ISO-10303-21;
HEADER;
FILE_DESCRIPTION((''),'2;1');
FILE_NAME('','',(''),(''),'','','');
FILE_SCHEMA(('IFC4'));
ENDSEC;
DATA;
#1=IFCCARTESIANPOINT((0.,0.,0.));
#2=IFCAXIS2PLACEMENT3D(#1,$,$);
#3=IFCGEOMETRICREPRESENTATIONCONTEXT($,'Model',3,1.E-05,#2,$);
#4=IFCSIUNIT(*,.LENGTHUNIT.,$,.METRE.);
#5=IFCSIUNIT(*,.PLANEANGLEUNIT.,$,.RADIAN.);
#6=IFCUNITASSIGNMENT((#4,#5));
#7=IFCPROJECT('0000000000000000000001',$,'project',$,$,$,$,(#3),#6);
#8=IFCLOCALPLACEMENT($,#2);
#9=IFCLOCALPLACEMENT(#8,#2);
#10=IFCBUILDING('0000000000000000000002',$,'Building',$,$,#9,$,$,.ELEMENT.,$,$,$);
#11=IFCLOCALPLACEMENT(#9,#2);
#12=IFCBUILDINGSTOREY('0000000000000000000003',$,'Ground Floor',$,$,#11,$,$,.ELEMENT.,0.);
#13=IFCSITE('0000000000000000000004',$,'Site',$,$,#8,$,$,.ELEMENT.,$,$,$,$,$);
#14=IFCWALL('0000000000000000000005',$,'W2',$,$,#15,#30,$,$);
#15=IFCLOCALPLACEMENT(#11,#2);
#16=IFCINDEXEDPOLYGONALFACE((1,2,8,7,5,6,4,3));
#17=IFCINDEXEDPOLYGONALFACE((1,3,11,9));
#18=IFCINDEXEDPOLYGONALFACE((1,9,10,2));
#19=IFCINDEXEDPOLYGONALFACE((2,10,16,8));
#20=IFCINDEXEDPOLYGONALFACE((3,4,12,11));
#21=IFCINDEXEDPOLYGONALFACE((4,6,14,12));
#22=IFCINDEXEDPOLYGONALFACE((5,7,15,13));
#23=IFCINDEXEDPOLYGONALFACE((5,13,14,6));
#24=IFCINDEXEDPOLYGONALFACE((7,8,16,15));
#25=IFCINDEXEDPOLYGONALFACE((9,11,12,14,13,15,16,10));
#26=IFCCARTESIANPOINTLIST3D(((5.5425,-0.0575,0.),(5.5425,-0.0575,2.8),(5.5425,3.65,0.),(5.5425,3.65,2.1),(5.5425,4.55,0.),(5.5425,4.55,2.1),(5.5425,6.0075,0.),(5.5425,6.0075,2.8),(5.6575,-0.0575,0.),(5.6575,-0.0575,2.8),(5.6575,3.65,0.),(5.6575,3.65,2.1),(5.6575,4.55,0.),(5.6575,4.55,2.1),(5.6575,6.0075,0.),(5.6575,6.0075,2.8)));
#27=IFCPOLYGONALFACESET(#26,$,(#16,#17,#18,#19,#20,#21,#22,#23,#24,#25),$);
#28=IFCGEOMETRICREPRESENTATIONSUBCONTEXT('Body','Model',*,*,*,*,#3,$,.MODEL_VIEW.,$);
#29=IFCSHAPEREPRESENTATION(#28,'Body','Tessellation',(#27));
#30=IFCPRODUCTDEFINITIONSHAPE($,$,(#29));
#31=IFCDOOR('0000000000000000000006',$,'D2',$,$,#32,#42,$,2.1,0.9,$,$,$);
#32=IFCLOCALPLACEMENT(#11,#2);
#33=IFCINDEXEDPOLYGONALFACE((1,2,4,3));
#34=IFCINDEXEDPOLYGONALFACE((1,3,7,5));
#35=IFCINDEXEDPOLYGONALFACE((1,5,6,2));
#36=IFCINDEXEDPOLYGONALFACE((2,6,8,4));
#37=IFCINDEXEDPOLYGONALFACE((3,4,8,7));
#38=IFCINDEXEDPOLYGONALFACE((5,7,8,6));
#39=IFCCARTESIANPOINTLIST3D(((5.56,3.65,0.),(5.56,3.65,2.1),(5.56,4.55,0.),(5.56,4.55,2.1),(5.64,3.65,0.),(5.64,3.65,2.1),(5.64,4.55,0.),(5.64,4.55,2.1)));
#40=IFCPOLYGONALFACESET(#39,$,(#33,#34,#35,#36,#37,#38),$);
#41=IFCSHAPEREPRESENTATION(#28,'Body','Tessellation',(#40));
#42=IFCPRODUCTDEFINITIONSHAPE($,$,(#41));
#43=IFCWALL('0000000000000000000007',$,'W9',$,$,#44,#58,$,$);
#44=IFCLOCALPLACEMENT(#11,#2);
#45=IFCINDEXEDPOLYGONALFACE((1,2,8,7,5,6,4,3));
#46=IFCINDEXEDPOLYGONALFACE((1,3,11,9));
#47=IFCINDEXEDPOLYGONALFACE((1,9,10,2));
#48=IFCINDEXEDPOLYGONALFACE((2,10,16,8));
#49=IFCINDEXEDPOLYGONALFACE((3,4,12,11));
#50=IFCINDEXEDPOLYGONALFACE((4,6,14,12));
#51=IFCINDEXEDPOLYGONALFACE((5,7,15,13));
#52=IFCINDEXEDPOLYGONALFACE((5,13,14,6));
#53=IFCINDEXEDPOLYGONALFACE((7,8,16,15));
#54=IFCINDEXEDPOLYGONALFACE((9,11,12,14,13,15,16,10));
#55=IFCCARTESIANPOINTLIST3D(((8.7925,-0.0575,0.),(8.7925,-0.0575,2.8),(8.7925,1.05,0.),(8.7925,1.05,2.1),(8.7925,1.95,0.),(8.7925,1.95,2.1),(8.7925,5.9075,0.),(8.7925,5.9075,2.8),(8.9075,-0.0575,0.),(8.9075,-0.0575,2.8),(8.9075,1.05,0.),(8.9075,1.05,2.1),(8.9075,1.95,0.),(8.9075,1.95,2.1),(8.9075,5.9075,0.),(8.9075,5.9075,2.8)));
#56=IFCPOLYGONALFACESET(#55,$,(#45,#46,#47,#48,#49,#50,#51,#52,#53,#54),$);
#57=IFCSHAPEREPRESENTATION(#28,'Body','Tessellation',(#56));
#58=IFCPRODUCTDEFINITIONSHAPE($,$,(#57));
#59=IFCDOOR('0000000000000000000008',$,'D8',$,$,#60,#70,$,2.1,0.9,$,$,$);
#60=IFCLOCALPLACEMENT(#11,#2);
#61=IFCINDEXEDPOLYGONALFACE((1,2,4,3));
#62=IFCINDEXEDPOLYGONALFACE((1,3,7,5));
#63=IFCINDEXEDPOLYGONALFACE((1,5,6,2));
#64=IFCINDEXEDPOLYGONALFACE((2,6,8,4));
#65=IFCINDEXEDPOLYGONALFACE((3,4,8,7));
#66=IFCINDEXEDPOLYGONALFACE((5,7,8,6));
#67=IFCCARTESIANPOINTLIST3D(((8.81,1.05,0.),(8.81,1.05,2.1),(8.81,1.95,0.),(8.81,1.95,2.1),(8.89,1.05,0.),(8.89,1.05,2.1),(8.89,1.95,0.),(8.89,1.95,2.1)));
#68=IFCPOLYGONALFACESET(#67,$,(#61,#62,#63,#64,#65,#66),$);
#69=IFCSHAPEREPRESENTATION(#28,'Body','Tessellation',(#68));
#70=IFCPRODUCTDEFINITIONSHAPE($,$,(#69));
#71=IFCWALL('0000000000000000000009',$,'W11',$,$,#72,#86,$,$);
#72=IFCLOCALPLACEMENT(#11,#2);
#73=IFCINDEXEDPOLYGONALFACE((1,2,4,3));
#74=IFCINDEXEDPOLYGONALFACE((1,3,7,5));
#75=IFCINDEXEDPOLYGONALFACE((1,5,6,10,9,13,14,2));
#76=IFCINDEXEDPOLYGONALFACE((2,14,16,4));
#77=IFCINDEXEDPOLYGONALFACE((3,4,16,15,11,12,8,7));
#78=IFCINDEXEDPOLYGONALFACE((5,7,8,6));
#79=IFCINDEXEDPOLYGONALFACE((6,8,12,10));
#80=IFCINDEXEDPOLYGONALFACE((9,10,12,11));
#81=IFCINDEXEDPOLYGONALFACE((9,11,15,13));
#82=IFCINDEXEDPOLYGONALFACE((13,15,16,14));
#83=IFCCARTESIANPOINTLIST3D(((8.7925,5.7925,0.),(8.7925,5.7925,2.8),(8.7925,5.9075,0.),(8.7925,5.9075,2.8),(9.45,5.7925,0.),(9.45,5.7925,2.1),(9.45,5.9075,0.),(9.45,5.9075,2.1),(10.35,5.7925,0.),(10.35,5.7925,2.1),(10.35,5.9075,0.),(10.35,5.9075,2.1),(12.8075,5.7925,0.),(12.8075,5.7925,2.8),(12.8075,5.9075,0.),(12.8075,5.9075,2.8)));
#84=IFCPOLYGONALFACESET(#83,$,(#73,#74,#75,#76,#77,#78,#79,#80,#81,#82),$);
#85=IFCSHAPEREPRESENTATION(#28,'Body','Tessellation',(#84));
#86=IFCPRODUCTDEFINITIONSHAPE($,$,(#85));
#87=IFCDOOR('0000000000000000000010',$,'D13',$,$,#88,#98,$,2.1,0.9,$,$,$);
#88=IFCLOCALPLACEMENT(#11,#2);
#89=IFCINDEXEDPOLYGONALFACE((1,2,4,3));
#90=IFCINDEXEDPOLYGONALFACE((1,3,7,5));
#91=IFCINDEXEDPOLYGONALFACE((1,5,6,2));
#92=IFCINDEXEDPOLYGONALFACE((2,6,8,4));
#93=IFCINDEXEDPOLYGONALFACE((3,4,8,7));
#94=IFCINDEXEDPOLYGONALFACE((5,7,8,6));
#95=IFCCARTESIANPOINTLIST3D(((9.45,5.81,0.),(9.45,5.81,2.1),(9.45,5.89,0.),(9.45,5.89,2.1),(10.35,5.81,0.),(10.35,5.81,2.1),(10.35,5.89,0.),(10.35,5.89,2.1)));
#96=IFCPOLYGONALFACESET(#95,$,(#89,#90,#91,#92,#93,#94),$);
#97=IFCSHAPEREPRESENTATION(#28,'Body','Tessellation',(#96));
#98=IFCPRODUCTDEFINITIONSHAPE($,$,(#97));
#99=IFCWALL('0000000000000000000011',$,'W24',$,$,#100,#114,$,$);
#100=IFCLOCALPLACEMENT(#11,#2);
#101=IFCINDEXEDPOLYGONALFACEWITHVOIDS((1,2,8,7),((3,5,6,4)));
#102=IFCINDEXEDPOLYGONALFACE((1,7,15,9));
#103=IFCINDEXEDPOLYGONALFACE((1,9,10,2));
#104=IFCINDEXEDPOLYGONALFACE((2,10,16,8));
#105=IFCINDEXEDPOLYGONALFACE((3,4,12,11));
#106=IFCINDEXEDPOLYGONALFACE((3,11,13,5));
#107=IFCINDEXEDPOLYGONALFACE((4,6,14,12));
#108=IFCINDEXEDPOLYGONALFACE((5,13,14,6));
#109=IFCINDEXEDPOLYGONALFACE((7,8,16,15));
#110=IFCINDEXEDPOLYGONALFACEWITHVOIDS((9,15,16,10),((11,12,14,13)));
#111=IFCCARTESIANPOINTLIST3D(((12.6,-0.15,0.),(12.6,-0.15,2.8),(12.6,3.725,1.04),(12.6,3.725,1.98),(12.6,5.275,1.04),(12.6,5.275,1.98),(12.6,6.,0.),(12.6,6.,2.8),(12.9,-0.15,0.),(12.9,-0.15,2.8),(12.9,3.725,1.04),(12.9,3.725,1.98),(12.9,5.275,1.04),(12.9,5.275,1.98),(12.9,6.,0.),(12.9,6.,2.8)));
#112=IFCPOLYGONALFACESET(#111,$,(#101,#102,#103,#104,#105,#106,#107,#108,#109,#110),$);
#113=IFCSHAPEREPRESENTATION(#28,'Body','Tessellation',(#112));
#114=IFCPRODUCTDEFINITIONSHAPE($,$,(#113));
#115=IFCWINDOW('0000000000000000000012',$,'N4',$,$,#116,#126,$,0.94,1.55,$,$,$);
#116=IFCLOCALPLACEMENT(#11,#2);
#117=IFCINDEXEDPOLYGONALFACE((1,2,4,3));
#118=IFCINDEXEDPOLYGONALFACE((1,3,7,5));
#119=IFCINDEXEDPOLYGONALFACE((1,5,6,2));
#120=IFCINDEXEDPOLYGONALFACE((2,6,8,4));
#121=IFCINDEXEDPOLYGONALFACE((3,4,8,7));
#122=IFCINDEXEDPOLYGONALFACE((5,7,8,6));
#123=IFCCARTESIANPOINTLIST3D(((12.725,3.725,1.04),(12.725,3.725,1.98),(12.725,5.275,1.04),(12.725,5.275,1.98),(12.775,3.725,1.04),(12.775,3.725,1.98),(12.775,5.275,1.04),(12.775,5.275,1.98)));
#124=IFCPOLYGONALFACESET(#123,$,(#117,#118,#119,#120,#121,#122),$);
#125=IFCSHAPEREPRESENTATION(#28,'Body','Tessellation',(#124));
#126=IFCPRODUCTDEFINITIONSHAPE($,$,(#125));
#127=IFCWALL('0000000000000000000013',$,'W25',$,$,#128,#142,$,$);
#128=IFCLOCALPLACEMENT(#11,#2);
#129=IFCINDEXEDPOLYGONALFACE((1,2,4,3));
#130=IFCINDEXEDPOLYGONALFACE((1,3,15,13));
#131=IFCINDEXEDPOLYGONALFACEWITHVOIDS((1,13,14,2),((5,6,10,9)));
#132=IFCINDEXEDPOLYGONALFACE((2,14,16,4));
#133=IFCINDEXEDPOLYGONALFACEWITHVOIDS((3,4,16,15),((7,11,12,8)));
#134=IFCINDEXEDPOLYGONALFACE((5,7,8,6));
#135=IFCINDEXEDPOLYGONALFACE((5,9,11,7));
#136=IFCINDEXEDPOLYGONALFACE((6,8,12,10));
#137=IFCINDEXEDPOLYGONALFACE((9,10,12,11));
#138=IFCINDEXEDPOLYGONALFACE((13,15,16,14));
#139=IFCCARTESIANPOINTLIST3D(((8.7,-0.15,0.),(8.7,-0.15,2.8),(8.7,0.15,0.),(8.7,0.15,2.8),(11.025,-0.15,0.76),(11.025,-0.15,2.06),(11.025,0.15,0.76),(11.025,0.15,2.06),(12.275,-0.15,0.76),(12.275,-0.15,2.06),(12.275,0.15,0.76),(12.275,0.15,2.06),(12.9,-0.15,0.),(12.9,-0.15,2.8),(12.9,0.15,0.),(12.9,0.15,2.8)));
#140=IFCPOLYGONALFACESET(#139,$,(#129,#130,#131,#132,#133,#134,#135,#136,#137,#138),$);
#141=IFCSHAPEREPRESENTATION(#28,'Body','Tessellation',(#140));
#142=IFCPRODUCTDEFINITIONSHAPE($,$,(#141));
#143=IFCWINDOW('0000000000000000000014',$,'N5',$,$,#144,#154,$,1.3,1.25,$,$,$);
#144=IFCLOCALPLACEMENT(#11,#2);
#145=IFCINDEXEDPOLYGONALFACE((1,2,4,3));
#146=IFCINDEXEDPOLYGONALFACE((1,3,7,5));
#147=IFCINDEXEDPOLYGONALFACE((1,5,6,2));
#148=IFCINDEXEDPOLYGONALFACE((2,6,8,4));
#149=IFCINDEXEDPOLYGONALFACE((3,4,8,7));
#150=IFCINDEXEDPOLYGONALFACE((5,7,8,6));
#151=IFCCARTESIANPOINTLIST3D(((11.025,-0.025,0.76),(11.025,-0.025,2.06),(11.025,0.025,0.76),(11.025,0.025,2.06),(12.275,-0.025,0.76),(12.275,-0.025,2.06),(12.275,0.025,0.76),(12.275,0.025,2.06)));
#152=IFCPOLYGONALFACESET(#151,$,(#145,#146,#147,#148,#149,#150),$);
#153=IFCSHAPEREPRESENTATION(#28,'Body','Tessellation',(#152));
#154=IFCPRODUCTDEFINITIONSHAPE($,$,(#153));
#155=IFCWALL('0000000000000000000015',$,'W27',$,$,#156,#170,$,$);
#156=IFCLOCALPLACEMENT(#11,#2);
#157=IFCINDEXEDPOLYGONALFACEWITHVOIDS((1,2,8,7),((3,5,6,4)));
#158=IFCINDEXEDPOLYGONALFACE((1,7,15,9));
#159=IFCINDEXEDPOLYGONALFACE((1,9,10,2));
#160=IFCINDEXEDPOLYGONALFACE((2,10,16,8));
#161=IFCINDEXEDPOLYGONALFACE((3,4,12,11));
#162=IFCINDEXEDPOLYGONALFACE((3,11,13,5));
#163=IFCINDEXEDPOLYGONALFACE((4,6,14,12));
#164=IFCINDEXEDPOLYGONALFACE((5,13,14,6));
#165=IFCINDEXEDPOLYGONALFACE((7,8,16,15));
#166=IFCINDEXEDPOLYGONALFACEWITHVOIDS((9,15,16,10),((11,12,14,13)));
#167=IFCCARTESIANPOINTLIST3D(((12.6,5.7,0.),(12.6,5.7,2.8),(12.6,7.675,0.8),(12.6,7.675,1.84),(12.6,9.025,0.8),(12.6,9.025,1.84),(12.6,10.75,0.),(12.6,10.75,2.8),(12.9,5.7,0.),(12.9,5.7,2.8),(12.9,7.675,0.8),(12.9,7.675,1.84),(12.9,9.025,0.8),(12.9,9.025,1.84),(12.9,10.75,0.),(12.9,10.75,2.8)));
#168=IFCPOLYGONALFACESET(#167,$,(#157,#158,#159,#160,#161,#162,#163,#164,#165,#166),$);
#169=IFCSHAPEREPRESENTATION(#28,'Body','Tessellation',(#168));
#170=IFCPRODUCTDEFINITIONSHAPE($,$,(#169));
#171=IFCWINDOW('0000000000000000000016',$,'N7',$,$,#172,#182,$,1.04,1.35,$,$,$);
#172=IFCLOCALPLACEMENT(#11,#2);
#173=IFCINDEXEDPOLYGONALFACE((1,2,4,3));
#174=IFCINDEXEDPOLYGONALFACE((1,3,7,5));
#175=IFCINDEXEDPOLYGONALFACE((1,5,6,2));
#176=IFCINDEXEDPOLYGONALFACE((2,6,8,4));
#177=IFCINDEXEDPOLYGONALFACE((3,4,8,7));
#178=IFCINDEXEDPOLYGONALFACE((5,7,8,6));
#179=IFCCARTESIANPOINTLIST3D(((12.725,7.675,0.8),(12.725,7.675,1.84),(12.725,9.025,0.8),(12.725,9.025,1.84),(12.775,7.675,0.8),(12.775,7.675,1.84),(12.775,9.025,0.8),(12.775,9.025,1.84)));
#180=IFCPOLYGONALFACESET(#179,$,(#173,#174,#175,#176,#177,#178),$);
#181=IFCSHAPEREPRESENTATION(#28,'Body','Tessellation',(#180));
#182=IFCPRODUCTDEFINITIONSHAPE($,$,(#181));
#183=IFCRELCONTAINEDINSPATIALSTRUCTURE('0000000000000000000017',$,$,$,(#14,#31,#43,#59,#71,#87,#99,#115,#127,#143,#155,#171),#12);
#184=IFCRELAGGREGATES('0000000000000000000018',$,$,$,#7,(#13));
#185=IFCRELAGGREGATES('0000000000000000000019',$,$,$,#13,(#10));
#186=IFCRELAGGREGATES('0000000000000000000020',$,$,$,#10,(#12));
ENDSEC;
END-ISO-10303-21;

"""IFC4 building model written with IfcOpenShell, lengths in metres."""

from ifc_helpers import new_model, si_unit, frame, frame_2d, origin, origin_2d, place, context, subcontext, project, spatial, rectangle, extrude, element, fill, save


model = new_model("IFC4")

# Units and contexts
model_context = context("Model", 3, precision=1e-05, world=origin())
body_context = subcontext(model_context, "Body", "Model", "MODEL_VIEW")
ifc_project = project(units=[si_unit("LENGTHUNIT", "METRE"), si_unit("PLANEANGLEUNIT", "RADIAN")], contexts=[model_context])

# Site, building, storey
site_placement = place(None, origin())
site = spatial("IfcSite", under=ifc_project, at=site_placement, Name="Site", CompositionType="ELEMENT")
building_placement = place(site_placement, origin())
building = spatial("IfcBuilding", under=site, at=building_placement, Name="Building", CompositionType="ELEMENT")
storey_placement = place(building_placement, origin())
storey = spatial("IfcBuildingStorey", under=building, at=storey_placement, Name="Ground Floor", CompositionType="ELEMENT", Elevation=0.0)

# Walls, openings, doors
wall_1_placement = place(storey_placement, frame((5.6, 0.0, 0.0), x_axis=(0.0, 1.0, 0.0)))
wall_1 = element("IfcWall", 1, at=wall_1_placement, inside=storey, Name="W2", context=body_context, shape_type="SweptSolid", body=[
    extrude(rectangle(XDim=6.065, YDim=0.115, at=frame_2d((2.975, 0.0))), origin(), (0.0, 0.0, 1.0), 2.8),
])
opening_1_placement = place(wall_1_placement, frame((4.1, 0.0, 0.0)))
opening_1 = element("IfcOpeningElement", 2, at=opening_1_placement, cuts=wall_1, context=body_context, shape_type="SweptSolid", body=[
    extrude(rectangle(XDim=0.9, YDim=0.215, at=origin_2d()), origin(), (0.0, 0.0, 1.0), 2.1),
])
door_1_placement = place(opening_1_placement, origin())
door_1 = element("IfcDoor", 3, at=door_1_placement, inside=storey, Name="D2", OverallHeight=2.1, OverallWidth=0.9, context=body_context, shape_type="SweptSolid", body=[
    extrude(rectangle(XDim=0.9, YDim=0.08, at=origin_2d()), origin(), (0.0, 0.0, 1.0), 2.1),
])
fill(opening_1, door_1)
wall_2_placement = place(storey_placement, frame((8.85, 0.0, 0.0), x_axis=(0.0, 1.0, 0.0)))
wall_2 = element("IfcWall", 4, at=wall_2_placement, inside=storey, Name="W9", context=body_context, shape_type="SweptSolid", body=[
    extrude(rectangle(XDim=5.965, YDim=0.115, at=frame_2d((2.925, 0.0))), origin(), (0.0, 0.0, 1.0), 2.8),
])
opening_2_placement = place(wall_2_placement, frame((1.5, 0.0, 0.0)))
opening_2 = element("IfcOpeningElement", 5, at=opening_2_placement, cuts=wall_2, context=body_context, shape_type="SweptSolid", body=[
    extrude(rectangle(XDim=0.9, YDim=0.215, at=origin_2d()), origin(), (0.0, 0.0, 1.0), 2.1),
])
door_2_placement = place(opening_2_placement, origin())
door_2 = element("IfcDoor", 6, at=door_2_placement, inside=storey, Name="D8", OverallHeight=2.1, OverallWidth=0.9, context=body_context, shape_type="SweptSolid", body=[
    extrude(rectangle(XDim=0.9, YDim=0.08, at=origin_2d()), origin(), (0.0, 0.0, 1.0), 2.1),
])
fill(opening_2, door_2)
wall_3_placement = place(storey_placement, frame((8.85, 5.85, 0.0), x_axis=(1.0, 0.0, 0.0)))
wall_3 = element("IfcWall", 7, at=wall_3_placement, inside=storey, Name="W11", context=body_context, shape_type="SweptSolid", body=[
    extrude(rectangle(XDim=4.015, YDim=0.115, at=frame_2d((1.95, 0.0))), origin(), (0.0, 0.0, 1.0), 2.8),
])
opening_3_placement = place(wall_3_placement, frame((1.05, 0.0, 0.0)))
opening_3 = element("IfcOpeningElement", 8, at=opening_3_placement, cuts=wall_3, context=body_context, shape_type="SweptSolid", body=[
    extrude(rectangle(XDim=0.9, YDim=0.215, at=origin_2d()), origin(), (0.0, 0.0, 1.0), 2.1),
])
door_3_placement = place(opening_3_placement, origin())
door_3 = element("IfcDoor", 9, at=door_3_placement, inside=storey, Name="D13", OverallHeight=2.1, OverallWidth=0.9, context=body_context, shape_type="SweptSolid", body=[
    extrude(rectangle(XDim=0.9, YDim=0.08, at=origin_2d()), origin(), (0.0, 0.0, 1.0), 2.1),
])
fill(opening_3, door_3)

# Walls, openings, windows
wall_4_placement = place(storey_placement, frame((12.75, 0.0, 0.0), x_axis=(0.0, 1.0, 0.0)))
wall_4 = element("IfcWall", 10, at=wall_4_placement, inside=storey, Name="W24", context=body_context, shape_type="SweptSolid", body=[
    extrude(rectangle(XDim=6.15, YDim=0.3, at=frame_2d((2.925, 0.0))), origin(), (0.0, 0.0, 1.0), 2.8),
])
opening_4_placement = place(wall_4_placement, frame((4.5, 0.0, 1.04)))
opening_4 = element("IfcOpeningElement", 11, at=opening_4_placement, cuts=wall_4, context=body_context, shape_type="SweptSolid", body=[
    extrude(rectangle(XDim=1.55, YDim=0.4, at=origin_2d()), origin(), (0.0, 0.0, 1.0), 0.94),
])
window_1_placement = place(opening_4_placement, origin())
window_1 = element("IfcWindow", 12, at=window_1_placement, inside=storey, Name="N4", OverallHeight=0.94, OverallWidth=1.55, context=body_context, shape_type="SweptSolid", body=[
    extrude(rectangle(XDim=1.55, YDim=0.05, at=origin_2d()), origin(), (0.0, 0.0, 1.0), 0.94),
])
fill(opening_4, window_1)
wall_5_placement = place(storey_placement, frame((8.85, 0.0, 0.0), x_axis=(1.0, 0.0, 0.0)))
wall_5 = element("IfcWall", 13, at=wall_5_placement, inside=storey, Name="W25", context=body_context, shape_type="SweptSolid", body=[
    extrude(rectangle(XDim=4.2, YDim=0.3, at=frame_2d((1.95, 0.0))), origin(), (0.0, 0.0, 1.0), 2.8),
])
opening_5_placement = place(wall_5_placement, frame((2.8, 0.0, 0.76)))
opening_5 = element("IfcOpeningElement", 14, at=opening_5_placement, cuts=wall_5, context=body_context, shape_type="SweptSolid", body=[
    extrude(rectangle(XDim=1.25, YDim=0.4, at=origin_2d()), origin(), (0.0, 0.0, 1.0), 1.3),
])
window_2_placement = place(opening_5_placement, origin())
window_2 = element("IfcWindow", 15, at=window_2_placement, inside=storey, Name="N5", OverallHeight=1.3, OverallWidth=1.25, context=body_context, shape_type="SweptSolid", body=[
    extrude(rectangle(XDim=1.25, YDim=0.05, at=origin_2d()), origin(), (0.0, 0.0, 1.0), 1.3),
])
fill(opening_5, window_2)
wall_6_placement = place(storey_placement, frame((12.75, 5.85, 0.0), x_axis=(0.0, 1.0, 0.0)))
wall_6 = element("IfcWall", 16, at=wall_6_placement, inside=storey, Name="W27", context=body_context, shape_type="SweptSolid", body=[
    extrude(rectangle(XDim=5.05, YDim=0.3, at=frame_2d((2.375, 0.0))), origin(), (0.0, 0.0, 1.0), 2.8),
])
opening_6_placement = place(wall_6_placement, frame((2.5, 0.0, 0.8)))
opening_6 = element("IfcOpeningElement", 17, at=opening_6_placement, cuts=wall_6, context=body_context, shape_type="SweptSolid", body=[
    extrude(rectangle(XDim=1.35, YDim=0.4, at=origin_2d()), origin(), (0.0, 0.0, 1.0), 1.04),
])
window_3_placement = place(opening_6_placement, origin())
window_3 = element("IfcWindow", 18, at=window_3_placement, inside=storey, Name="N7", OverallHeight=1.04, OverallWidth=1.35, context=body_context, shape_type="SweptSolid", body=[
    extrude(rectangle(XDim=1.35, YDim=0.05, at=origin_2d()), origin(), (0.0, 0.0, 1.0), 1.04),
])
fill(opening_6, window_3)

save(model, "model.ifc")
